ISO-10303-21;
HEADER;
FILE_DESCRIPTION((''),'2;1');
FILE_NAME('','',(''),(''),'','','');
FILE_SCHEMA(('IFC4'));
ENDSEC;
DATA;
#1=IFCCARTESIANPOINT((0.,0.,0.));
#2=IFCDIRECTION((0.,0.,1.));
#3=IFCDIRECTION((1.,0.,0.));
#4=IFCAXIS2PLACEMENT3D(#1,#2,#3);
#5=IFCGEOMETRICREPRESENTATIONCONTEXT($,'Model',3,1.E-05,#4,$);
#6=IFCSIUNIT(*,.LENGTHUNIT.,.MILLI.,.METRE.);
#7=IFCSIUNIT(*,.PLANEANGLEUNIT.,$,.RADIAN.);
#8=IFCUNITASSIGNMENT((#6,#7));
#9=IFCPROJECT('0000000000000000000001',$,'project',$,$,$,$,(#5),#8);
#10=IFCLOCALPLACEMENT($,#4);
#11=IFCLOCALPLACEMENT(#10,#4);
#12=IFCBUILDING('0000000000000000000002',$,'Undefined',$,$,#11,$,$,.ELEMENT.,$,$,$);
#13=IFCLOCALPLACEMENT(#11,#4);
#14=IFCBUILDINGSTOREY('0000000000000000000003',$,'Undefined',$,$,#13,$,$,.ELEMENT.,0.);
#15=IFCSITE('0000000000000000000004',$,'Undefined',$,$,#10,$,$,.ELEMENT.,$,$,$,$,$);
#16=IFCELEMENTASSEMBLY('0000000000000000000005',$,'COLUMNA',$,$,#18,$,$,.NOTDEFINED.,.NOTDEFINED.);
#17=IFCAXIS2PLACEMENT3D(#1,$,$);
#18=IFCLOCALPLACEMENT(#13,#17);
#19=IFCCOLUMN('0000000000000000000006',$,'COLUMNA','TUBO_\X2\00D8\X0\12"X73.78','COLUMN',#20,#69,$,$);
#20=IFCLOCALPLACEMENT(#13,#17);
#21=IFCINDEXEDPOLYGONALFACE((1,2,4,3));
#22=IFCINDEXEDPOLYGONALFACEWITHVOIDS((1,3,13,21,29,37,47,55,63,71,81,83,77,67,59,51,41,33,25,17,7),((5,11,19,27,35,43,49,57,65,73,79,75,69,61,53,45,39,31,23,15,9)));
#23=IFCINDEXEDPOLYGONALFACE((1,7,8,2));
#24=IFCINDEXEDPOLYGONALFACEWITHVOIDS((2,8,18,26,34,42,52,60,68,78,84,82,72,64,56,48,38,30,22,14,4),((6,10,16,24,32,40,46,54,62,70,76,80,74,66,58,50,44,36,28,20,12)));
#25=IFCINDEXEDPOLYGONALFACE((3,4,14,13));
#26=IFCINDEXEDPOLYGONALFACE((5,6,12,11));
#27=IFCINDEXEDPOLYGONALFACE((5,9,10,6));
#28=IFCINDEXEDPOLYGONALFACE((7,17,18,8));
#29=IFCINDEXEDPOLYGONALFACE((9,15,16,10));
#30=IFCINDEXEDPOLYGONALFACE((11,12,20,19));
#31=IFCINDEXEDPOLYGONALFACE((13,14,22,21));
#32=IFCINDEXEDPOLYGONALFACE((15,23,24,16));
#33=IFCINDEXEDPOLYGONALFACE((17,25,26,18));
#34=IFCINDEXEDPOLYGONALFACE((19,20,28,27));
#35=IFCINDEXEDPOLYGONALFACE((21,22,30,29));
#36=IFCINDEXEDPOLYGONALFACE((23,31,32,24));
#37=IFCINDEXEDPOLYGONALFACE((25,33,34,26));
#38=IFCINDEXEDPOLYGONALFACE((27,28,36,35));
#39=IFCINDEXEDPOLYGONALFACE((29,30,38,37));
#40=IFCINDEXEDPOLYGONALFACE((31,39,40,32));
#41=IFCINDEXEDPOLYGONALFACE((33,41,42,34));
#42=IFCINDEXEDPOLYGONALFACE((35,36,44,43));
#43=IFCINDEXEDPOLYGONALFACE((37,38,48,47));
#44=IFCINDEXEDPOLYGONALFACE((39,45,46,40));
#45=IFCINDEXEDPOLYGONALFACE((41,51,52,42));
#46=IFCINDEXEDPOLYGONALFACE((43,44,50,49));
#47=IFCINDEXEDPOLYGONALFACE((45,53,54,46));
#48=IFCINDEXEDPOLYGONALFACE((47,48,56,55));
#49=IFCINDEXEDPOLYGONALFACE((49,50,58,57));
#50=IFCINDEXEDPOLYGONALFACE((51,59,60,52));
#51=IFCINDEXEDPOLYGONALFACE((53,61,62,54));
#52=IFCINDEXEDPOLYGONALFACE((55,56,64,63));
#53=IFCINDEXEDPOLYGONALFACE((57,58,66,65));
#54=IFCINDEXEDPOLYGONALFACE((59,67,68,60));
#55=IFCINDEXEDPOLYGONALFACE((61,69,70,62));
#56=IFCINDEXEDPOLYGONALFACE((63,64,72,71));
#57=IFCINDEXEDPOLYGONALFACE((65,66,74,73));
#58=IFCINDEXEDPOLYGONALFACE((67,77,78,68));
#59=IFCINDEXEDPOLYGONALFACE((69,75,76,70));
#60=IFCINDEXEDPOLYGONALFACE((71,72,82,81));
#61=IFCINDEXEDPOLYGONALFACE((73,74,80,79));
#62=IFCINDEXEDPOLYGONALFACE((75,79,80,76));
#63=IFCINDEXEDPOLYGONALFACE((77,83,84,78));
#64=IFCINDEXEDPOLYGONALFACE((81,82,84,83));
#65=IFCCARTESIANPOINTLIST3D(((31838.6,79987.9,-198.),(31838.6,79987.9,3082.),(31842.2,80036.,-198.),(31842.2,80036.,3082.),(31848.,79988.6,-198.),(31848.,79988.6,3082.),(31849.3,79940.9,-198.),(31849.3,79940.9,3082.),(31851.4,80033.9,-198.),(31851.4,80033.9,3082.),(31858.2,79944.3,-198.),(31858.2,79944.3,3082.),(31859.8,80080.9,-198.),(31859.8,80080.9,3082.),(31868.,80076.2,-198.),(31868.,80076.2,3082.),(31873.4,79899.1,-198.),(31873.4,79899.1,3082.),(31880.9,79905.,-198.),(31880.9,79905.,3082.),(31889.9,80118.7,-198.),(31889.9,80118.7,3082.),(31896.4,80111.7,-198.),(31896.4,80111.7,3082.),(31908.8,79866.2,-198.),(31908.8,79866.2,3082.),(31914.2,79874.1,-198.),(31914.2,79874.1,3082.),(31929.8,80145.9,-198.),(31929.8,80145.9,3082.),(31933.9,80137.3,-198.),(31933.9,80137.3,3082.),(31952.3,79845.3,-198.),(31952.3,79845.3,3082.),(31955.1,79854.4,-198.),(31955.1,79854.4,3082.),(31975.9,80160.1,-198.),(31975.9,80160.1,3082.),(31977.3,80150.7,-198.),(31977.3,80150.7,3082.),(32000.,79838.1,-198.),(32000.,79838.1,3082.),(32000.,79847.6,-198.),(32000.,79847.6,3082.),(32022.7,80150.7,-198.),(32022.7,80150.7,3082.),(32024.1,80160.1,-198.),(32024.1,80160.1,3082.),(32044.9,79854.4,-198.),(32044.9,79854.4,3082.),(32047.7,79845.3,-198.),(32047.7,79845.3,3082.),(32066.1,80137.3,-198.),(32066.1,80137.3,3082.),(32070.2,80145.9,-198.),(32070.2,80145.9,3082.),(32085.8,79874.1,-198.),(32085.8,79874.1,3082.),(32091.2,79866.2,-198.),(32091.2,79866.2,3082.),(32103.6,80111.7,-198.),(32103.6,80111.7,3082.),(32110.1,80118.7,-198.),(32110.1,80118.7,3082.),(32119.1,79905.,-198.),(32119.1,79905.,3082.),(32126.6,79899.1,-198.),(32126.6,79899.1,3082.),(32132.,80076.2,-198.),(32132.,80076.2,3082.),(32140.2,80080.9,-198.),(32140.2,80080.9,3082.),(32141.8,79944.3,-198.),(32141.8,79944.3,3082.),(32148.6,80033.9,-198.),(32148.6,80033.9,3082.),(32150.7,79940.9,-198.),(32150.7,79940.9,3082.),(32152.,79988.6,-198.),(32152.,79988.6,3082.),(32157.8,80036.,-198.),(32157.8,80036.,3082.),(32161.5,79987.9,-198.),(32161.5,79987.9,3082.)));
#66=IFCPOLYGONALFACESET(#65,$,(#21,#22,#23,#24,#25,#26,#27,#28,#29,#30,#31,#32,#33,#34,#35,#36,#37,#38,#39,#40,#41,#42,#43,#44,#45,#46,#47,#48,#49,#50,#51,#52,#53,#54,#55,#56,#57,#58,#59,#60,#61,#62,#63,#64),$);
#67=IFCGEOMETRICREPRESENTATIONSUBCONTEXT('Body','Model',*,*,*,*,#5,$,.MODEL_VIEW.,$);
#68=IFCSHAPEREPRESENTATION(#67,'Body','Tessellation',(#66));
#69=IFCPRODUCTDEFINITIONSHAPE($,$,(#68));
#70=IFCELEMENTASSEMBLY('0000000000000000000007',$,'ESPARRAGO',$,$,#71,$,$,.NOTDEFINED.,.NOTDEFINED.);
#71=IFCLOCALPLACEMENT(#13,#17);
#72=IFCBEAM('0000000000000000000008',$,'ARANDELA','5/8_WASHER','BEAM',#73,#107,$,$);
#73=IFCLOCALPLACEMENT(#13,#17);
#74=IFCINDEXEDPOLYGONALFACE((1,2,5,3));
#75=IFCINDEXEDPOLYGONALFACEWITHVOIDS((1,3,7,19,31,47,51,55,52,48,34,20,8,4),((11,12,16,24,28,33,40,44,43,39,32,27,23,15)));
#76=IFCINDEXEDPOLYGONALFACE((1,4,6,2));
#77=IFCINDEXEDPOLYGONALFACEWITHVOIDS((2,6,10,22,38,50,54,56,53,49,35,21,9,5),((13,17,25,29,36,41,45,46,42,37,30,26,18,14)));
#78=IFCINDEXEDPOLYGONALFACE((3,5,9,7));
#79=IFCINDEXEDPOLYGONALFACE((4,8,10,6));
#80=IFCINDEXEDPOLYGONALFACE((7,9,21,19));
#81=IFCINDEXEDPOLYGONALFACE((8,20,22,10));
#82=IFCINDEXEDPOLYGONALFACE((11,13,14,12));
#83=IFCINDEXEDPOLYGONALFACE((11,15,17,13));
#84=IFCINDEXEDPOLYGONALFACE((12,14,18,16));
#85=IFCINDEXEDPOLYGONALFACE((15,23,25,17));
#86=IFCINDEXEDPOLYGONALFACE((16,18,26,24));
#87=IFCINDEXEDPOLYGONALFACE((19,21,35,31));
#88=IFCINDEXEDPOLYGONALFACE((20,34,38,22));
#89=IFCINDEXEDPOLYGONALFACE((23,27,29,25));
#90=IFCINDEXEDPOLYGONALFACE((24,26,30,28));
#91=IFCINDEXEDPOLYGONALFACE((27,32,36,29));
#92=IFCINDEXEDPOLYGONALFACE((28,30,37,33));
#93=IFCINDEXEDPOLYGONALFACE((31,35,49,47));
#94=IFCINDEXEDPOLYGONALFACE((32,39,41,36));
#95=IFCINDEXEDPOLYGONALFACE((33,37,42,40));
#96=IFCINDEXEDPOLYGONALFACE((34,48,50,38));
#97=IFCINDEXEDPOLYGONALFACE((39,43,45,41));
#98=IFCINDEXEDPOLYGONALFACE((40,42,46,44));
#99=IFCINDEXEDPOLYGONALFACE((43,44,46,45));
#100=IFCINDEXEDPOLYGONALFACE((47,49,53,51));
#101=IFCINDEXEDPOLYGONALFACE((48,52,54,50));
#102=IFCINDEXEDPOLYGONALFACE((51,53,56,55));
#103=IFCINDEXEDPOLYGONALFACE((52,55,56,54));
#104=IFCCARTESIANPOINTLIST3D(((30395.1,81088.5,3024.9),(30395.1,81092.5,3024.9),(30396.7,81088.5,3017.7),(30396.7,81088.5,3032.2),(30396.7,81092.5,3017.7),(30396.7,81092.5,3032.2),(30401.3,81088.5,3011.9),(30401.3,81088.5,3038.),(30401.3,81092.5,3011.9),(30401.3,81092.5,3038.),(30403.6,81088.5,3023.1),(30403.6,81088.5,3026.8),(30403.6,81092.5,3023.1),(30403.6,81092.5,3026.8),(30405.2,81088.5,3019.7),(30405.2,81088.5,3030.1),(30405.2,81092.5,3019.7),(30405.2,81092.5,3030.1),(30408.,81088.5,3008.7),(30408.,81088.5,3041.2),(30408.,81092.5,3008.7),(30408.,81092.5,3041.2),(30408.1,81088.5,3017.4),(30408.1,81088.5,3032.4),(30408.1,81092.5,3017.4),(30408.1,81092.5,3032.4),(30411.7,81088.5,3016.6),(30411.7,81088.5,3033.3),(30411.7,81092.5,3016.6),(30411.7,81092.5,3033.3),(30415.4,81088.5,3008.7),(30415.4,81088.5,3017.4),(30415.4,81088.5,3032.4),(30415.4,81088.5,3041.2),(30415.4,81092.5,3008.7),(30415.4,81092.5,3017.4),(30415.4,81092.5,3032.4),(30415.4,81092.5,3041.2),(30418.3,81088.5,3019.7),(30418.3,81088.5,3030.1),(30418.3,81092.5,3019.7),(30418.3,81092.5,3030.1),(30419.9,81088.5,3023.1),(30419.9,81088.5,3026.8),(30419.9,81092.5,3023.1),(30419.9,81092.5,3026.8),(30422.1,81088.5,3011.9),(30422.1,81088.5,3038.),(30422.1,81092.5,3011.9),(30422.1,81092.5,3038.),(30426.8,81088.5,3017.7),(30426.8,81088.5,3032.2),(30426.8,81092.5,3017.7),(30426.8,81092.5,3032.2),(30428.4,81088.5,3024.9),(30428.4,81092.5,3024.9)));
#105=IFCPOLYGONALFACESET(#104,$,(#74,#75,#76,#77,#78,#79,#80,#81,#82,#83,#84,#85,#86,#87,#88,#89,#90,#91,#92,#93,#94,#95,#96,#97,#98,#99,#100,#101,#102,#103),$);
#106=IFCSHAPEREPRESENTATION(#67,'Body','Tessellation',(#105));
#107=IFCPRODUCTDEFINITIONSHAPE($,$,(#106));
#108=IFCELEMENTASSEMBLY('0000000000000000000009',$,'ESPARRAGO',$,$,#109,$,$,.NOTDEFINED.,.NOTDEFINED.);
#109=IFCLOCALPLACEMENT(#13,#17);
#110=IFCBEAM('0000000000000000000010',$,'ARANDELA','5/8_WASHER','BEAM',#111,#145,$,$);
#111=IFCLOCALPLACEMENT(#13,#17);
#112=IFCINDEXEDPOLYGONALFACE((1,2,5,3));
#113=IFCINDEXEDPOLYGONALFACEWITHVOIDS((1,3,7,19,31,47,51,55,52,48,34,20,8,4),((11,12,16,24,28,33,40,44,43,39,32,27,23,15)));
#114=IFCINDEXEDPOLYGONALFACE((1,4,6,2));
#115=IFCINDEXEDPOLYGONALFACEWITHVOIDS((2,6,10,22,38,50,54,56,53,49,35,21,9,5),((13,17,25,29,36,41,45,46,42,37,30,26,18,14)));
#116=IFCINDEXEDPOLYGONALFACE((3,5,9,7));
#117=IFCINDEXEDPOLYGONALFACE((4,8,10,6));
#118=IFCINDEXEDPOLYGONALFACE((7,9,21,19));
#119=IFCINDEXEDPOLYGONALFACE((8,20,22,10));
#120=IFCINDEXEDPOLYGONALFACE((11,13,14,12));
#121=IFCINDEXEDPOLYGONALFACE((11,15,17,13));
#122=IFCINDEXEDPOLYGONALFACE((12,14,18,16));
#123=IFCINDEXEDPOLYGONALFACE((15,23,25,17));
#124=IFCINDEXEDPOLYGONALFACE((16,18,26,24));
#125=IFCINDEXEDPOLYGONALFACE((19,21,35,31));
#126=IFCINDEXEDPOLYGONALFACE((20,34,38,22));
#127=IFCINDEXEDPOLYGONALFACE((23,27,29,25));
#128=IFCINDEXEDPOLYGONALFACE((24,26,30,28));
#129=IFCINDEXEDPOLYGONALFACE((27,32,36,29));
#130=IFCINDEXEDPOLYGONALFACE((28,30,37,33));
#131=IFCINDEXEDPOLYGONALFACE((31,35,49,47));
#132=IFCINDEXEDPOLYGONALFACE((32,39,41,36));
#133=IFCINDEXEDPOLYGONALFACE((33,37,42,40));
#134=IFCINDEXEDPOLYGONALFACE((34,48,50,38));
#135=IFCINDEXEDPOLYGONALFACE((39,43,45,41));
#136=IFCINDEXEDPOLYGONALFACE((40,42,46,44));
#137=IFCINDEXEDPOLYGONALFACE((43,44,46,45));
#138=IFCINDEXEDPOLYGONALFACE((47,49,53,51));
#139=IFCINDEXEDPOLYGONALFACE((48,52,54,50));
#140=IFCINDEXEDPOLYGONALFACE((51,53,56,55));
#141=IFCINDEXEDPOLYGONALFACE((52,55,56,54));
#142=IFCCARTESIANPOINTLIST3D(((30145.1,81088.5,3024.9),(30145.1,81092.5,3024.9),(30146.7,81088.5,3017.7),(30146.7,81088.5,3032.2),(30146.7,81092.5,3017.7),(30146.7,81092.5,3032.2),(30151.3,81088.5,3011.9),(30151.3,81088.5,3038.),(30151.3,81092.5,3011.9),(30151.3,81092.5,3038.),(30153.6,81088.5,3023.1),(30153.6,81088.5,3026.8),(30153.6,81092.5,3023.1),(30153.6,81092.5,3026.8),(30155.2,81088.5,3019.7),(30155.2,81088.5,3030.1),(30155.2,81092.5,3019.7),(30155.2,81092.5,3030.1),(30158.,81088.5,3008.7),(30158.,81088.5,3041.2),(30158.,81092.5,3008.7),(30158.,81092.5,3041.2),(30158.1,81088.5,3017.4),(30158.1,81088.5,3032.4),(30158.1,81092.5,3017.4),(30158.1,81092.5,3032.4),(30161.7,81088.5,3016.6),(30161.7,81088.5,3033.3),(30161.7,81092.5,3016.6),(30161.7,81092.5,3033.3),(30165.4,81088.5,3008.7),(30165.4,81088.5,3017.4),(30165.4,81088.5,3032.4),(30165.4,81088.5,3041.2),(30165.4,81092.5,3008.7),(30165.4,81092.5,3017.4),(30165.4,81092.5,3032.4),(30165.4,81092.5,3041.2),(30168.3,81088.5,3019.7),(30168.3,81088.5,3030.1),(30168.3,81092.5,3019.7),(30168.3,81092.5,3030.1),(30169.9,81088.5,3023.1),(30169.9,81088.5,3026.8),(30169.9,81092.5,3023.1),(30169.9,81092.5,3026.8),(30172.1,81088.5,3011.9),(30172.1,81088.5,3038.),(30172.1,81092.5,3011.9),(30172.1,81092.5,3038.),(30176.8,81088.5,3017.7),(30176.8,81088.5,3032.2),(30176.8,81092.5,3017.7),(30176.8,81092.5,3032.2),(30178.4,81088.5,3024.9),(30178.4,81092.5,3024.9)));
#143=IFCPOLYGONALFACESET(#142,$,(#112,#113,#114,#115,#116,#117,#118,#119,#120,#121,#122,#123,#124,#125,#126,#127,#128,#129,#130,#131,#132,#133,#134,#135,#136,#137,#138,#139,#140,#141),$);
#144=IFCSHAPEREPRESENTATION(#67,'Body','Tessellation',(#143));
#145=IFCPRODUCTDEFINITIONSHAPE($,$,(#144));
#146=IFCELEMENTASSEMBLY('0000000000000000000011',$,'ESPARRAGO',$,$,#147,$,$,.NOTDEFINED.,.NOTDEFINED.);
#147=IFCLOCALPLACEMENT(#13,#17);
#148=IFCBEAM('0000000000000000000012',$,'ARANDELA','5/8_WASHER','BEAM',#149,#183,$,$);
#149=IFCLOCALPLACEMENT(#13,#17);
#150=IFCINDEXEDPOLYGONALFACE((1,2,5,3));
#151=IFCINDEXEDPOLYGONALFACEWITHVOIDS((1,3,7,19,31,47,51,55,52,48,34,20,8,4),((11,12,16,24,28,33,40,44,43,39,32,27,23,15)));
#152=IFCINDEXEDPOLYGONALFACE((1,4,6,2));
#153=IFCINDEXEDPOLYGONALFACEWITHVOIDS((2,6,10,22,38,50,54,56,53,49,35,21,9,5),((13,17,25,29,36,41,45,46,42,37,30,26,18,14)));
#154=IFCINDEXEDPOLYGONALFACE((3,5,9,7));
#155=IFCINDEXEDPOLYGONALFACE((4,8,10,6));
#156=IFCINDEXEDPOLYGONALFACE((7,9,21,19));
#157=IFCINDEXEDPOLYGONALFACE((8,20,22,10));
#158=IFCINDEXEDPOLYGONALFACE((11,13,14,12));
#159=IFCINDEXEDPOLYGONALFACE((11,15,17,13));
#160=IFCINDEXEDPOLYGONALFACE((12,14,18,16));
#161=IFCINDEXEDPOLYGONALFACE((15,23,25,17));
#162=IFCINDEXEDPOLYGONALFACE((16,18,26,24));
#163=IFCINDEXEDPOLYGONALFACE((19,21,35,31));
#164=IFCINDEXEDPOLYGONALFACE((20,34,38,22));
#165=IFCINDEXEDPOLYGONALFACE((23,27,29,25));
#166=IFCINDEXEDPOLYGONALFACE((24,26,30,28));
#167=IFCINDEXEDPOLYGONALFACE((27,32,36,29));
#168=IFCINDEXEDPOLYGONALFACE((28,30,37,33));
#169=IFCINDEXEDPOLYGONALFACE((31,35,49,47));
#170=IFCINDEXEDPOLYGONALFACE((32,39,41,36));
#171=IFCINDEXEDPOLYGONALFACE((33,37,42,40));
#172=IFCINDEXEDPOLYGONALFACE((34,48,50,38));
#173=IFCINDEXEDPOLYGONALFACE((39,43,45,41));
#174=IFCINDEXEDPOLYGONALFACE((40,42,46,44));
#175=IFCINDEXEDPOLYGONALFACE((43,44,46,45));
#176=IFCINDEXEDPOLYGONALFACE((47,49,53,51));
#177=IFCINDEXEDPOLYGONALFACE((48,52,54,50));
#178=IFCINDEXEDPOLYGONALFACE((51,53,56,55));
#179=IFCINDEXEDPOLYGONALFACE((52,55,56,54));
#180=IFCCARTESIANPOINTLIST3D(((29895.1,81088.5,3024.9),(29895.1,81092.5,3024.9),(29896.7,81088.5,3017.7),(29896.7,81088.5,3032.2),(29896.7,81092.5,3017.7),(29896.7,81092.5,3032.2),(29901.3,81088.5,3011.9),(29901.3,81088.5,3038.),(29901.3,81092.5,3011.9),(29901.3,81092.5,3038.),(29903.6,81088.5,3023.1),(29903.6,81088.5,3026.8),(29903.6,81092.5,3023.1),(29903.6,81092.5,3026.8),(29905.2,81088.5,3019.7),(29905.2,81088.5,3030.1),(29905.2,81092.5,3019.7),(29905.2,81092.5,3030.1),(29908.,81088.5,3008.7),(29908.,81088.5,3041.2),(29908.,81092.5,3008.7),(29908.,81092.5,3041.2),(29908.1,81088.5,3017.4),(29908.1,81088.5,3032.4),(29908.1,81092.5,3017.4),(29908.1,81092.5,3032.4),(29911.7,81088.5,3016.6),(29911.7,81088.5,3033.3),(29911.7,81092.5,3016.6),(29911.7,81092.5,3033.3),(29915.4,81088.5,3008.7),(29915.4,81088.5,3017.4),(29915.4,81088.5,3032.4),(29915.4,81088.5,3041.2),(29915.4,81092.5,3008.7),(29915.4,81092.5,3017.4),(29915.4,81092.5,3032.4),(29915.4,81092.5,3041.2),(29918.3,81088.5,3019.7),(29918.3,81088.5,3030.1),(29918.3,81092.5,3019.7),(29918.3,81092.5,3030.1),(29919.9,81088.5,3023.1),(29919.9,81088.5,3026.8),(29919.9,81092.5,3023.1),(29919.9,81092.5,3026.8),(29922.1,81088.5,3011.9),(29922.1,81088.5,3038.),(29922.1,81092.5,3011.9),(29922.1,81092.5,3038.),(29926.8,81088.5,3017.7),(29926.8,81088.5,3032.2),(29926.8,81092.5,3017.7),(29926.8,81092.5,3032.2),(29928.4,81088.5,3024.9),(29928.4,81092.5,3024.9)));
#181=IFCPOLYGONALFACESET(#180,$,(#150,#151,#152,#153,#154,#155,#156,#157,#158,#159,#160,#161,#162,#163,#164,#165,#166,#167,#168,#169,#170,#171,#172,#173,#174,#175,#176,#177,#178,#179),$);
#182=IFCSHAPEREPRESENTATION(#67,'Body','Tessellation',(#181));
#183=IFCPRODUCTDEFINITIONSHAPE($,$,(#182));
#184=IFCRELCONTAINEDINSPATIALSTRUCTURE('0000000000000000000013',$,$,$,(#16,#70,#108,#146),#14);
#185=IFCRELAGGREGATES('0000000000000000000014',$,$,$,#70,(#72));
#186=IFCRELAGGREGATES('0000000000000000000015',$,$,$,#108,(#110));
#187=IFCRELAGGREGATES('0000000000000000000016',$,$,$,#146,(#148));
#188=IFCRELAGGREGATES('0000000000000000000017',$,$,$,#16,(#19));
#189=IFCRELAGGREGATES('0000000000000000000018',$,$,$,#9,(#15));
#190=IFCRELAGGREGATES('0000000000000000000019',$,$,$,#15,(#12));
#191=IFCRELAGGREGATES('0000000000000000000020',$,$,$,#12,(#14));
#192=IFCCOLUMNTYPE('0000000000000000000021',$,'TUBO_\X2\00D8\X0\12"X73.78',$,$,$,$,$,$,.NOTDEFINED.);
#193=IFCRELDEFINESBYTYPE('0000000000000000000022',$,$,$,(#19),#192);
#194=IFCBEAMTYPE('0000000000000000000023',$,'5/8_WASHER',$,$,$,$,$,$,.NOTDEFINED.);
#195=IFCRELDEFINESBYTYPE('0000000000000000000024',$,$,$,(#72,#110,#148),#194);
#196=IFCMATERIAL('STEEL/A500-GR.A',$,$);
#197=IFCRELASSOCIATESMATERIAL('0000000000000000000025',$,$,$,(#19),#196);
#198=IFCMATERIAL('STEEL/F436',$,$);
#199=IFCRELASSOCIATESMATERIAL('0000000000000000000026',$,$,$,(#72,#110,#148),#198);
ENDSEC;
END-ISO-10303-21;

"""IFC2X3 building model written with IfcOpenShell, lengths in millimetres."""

from ifc_helpers import new_model, si_unit, frame, origin_with_axes, origin_2d_with_axis, place, context, subcontext, project, spatial, polyline, hollow_circle, outline, extrude, clip, halfspace, material, type_object, element, aggregate, save


model = new_model("IFC2X3")

# Units and contexts
model_context = context("Model", 3, precision=1e-05, world=origin_with_axes())
body_context = subcontext(model_context, "Body", "Model", "MODEL_VIEW")
ifc_project = project(units=[si_unit("LENGTHUNIT", "METRE", prefix="MILLI"), si_unit("PLANEANGLEUNIT", "RADIAN")], contexts=[model_context])

# Site, building, storey
site_placement = place(None, origin_with_axes())
site = spatial("IfcSite", under=ifc_project, at=site_placement, Name="Undefined", CompositionType="ELEMENT")
building_placement = place(site_placement, origin_with_axes())
building = spatial("IfcBuilding", under=site, at=building_placement, Name="Undefined", CompositionType="ELEMENT")
storey_placement = place(building_placement, origin_with_axes())
storey = spatial("IfcBuildingStorey", under=building, at=storey_placement, Name="Undefined", CompositionType="ELEMENT", Elevation=0.0)

# Element assembly, column
assembly_1_placement = place(storey_placement, origin_with_axes())
assembly_1 = element("IfcElementAssembly", 1, at=assembly_1_placement, inside=storey, Name="COLUMNA", AssemblyPlace="NOTDEFINED", PredefinedType="NOTDEFINED")
ifc_material_1 = material(Name="STEEL/A500-GR.A")
column_type = type_object("IfcColumnType", Name="TUBO_Ø12\"X73.78", PredefinedType="NOTDEFINED")
column_placement = place(assembly_1_placement, frame((32000.0, 80000.0, -210.0), z_axis=(0.0, 0.0, 1.0), x_axis=(-1.0, 0.0, 0.0)))
column = element("IfcColumn", 2, at=column_placement, type_object=column_type, material=ifc_material_1, Name="COLUMNA", Description="TUBO_Ø12\"X73.78", ObjectType="COLUMN", context=body_context, shape_type="Clipping", body=[
    clip(extrude(hollow_circle(Radius=161.9, WallThickness=9.5, at=origin_2d_with_axis()), frame((0.0, 0.0, 3292.0), z_axis=(0.0, 0.0, -1.0), x_axis=(0.0, 1.0, 0.0)), (0.0, 0.0, 1.0), 3292.0), halfspace(frame((-161.9, 0.0, 12.0), z_axis=(0.0, 0.0, 1.0), x_axis=(0.0, 1.0, 0.0)), True)),
])

# Element assemblies, beams
assembly_2_placement = place(storey_placement, origin_with_axes())
assembly_2 = element("IfcElementAssembly", 3, at=assembly_2_placement, inside=storey, Name="ESPARRAGO", AssemblyPlace="NOTDEFINED", PredefinedType="NOTDEFINED")
ifc_material_2 = material(Name="STEEL/F436")
beam_type_1 = type_object("IfcBeamType", Name="5/8_WASHER", PredefinedType="NOTDEFINED")
beam_1_placement = place(assembly_2_placement, frame((30411.7, 81088.5, 3024.9), z_axis=(0.0, 0.000086, 1.0), x_axis=(0.000015, 1.0, -0.000086)))
beam_1 = element("IfcBeam", 4, at=beam_1_placement, type_object=beam_type_1, material=ifc_material_2, Name="ARANDELA", Description="5/8_WASHER", ObjectType="BEAM", context=body_context, shape_type="SweptSolid", body=[
    extrude(outline(polyline([(10.4, 13.0), (15.0, 7.2), (16.7, 0.0), (15.0, -7.2), (10.4, -13.0), (3.7, -16.3), (-3.7, -16.3), (-10.4, -13.0), (-15.0, -7.2), (-16.7, 0.0), (-15.0, 7.2), (-10.4, 13.0), (-3.7, 16.3), (3.7, 16.3), (10.4, 13.0)]), holes=[polyline([(6.5, -5.2), (8.1, -1.9), (8.1, 1.9), (6.5, 5.2), (3.6, 7.5), (0.0, 8.3), (-3.6, 7.5), (-6.5, 5.2), (-8.1, 1.9), (-8.1, -1.9), (-6.5, -5.2), (-3.6, -7.5), (0.0, -8.3), (3.6, -7.5), (6.5, -5.2)])]), frame((4.0, 0.0, 0.0), z_axis=(-1.0, 0.0, 0.0), x_axis=(0.0, -1.0, 0.0)), (0.0, 0.0, 1.0), 4.0),
])
assembly_3_placement = place(storey_placement, origin_with_axes())
assembly_3 = element("IfcElementAssembly", 5, at=assembly_3_placement, inside=storey, Name="ESPARRAGO", AssemblyPlace="NOTDEFINED", PredefinedType="NOTDEFINED")
beam_2_placement = place(assembly_3_placement, frame((30161.7, 81088.5, 3024.9), z_axis=(0.0, 0.000086, 1.0), x_axis=(0.000015, 1.0, -0.000086)))
beam_2 = element("IfcBeam", 6, at=beam_2_placement, type_object=beam_type_1, material=ifc_material_2, Name="ARANDELA", Description="5/8_WASHER", ObjectType="BEAM", context=body_context, shape_type="SweptSolid", body=[
    extrude(outline(polyline([(10.4, 13.0), (15.0, 7.2), (16.7, 0.0), (15.0, -7.2), (10.4, -13.0), (3.7, -16.3), (-3.7, -16.3), (-10.4, -13.0), (-15.0, -7.2), (-16.7, 0.0), (-15.0, 7.2), (-10.4, 13.0), (-3.7, 16.3), (3.7, 16.3), (10.4, 13.0)]), holes=[polyline([(6.5, -5.2), (8.1, -1.9), (8.1, 1.9), (6.5, 5.2), (3.6, 7.5), (0.0, 8.3), (-3.6, 7.5), (-6.5, 5.2), (-8.1, 1.9), (-8.1, -1.9), (-6.5, -5.2), (-3.6, -7.5), (0.0, -8.3), (3.6, -7.5), (6.5, -5.2)])]), frame((4.0, 0.0, 0.0), z_axis=(-1.0, 0.0, 0.0), x_axis=(0.0, -1.0, 0.0)), (0.0, 0.0, 1.0), 4.0),
])
assembly_4_placement = place(storey_placement, origin_with_axes())
assembly_4 = element("IfcElementAssembly", 7, at=assembly_4_placement, inside=storey, Name="ESPARRAGO", AssemblyPlace="NOTDEFINED", PredefinedType="NOTDEFINED")
beam_3_placement = place(assembly_4_placement, frame((29911.7, 81088.5, 3024.9), z_axis=(0.0, 0.000086, 1.0), x_axis=(0.000015, 1.0, -0.000086)))
beam_3 = element("IfcBeam", 8, at=beam_3_placement, type_object=beam_type_1, material=ifc_material_2, Name="ARANDELA", Description="5/8_WASHER", ObjectType="BEAM", context=body_context, shape_type="SweptSolid", body=[
    extrude(outline(polyline([(10.4, 13.0), (15.0, 7.2), (16.7, 0.0), (15.0, -7.2), (10.4, -13.0), (3.7, -16.3), (-3.7, -16.3), (-10.4, -13.0), (-15.0, -7.2), (-16.7, 0.0), (-15.0, 7.2), (-10.4, 13.0), (-3.7, 16.3), (3.7, 16.3), (10.4, 13.0)]), holes=[polyline([(6.5, -5.2), (8.1, -1.9), (8.1, 1.9), (6.5, 5.2), (3.6, 7.5), (0.0, 8.3), (-3.6, 7.5), (-6.5, 5.2), (-8.1, 1.9), (-8.1, -1.9), (-6.5, -5.2), (-3.6, -7.5), (0.0, -8.3), (3.6, -7.5), (6.5, -5.2)])]), frame((4.0, 0.0, 0.0), z_axis=(-1.0, 0.0, 0.0), x_axis=(0.0, -1.0, 0.0)), (0.0, 0.0, 1.0), 4.0),
])

aggregate(assembly_2, [beam_1])
aggregate(assembly_3, [beam_2])
aggregate(assembly_4, [beam_3])

aggregate(assembly_1, [column])

save(model, "model.ifc")
